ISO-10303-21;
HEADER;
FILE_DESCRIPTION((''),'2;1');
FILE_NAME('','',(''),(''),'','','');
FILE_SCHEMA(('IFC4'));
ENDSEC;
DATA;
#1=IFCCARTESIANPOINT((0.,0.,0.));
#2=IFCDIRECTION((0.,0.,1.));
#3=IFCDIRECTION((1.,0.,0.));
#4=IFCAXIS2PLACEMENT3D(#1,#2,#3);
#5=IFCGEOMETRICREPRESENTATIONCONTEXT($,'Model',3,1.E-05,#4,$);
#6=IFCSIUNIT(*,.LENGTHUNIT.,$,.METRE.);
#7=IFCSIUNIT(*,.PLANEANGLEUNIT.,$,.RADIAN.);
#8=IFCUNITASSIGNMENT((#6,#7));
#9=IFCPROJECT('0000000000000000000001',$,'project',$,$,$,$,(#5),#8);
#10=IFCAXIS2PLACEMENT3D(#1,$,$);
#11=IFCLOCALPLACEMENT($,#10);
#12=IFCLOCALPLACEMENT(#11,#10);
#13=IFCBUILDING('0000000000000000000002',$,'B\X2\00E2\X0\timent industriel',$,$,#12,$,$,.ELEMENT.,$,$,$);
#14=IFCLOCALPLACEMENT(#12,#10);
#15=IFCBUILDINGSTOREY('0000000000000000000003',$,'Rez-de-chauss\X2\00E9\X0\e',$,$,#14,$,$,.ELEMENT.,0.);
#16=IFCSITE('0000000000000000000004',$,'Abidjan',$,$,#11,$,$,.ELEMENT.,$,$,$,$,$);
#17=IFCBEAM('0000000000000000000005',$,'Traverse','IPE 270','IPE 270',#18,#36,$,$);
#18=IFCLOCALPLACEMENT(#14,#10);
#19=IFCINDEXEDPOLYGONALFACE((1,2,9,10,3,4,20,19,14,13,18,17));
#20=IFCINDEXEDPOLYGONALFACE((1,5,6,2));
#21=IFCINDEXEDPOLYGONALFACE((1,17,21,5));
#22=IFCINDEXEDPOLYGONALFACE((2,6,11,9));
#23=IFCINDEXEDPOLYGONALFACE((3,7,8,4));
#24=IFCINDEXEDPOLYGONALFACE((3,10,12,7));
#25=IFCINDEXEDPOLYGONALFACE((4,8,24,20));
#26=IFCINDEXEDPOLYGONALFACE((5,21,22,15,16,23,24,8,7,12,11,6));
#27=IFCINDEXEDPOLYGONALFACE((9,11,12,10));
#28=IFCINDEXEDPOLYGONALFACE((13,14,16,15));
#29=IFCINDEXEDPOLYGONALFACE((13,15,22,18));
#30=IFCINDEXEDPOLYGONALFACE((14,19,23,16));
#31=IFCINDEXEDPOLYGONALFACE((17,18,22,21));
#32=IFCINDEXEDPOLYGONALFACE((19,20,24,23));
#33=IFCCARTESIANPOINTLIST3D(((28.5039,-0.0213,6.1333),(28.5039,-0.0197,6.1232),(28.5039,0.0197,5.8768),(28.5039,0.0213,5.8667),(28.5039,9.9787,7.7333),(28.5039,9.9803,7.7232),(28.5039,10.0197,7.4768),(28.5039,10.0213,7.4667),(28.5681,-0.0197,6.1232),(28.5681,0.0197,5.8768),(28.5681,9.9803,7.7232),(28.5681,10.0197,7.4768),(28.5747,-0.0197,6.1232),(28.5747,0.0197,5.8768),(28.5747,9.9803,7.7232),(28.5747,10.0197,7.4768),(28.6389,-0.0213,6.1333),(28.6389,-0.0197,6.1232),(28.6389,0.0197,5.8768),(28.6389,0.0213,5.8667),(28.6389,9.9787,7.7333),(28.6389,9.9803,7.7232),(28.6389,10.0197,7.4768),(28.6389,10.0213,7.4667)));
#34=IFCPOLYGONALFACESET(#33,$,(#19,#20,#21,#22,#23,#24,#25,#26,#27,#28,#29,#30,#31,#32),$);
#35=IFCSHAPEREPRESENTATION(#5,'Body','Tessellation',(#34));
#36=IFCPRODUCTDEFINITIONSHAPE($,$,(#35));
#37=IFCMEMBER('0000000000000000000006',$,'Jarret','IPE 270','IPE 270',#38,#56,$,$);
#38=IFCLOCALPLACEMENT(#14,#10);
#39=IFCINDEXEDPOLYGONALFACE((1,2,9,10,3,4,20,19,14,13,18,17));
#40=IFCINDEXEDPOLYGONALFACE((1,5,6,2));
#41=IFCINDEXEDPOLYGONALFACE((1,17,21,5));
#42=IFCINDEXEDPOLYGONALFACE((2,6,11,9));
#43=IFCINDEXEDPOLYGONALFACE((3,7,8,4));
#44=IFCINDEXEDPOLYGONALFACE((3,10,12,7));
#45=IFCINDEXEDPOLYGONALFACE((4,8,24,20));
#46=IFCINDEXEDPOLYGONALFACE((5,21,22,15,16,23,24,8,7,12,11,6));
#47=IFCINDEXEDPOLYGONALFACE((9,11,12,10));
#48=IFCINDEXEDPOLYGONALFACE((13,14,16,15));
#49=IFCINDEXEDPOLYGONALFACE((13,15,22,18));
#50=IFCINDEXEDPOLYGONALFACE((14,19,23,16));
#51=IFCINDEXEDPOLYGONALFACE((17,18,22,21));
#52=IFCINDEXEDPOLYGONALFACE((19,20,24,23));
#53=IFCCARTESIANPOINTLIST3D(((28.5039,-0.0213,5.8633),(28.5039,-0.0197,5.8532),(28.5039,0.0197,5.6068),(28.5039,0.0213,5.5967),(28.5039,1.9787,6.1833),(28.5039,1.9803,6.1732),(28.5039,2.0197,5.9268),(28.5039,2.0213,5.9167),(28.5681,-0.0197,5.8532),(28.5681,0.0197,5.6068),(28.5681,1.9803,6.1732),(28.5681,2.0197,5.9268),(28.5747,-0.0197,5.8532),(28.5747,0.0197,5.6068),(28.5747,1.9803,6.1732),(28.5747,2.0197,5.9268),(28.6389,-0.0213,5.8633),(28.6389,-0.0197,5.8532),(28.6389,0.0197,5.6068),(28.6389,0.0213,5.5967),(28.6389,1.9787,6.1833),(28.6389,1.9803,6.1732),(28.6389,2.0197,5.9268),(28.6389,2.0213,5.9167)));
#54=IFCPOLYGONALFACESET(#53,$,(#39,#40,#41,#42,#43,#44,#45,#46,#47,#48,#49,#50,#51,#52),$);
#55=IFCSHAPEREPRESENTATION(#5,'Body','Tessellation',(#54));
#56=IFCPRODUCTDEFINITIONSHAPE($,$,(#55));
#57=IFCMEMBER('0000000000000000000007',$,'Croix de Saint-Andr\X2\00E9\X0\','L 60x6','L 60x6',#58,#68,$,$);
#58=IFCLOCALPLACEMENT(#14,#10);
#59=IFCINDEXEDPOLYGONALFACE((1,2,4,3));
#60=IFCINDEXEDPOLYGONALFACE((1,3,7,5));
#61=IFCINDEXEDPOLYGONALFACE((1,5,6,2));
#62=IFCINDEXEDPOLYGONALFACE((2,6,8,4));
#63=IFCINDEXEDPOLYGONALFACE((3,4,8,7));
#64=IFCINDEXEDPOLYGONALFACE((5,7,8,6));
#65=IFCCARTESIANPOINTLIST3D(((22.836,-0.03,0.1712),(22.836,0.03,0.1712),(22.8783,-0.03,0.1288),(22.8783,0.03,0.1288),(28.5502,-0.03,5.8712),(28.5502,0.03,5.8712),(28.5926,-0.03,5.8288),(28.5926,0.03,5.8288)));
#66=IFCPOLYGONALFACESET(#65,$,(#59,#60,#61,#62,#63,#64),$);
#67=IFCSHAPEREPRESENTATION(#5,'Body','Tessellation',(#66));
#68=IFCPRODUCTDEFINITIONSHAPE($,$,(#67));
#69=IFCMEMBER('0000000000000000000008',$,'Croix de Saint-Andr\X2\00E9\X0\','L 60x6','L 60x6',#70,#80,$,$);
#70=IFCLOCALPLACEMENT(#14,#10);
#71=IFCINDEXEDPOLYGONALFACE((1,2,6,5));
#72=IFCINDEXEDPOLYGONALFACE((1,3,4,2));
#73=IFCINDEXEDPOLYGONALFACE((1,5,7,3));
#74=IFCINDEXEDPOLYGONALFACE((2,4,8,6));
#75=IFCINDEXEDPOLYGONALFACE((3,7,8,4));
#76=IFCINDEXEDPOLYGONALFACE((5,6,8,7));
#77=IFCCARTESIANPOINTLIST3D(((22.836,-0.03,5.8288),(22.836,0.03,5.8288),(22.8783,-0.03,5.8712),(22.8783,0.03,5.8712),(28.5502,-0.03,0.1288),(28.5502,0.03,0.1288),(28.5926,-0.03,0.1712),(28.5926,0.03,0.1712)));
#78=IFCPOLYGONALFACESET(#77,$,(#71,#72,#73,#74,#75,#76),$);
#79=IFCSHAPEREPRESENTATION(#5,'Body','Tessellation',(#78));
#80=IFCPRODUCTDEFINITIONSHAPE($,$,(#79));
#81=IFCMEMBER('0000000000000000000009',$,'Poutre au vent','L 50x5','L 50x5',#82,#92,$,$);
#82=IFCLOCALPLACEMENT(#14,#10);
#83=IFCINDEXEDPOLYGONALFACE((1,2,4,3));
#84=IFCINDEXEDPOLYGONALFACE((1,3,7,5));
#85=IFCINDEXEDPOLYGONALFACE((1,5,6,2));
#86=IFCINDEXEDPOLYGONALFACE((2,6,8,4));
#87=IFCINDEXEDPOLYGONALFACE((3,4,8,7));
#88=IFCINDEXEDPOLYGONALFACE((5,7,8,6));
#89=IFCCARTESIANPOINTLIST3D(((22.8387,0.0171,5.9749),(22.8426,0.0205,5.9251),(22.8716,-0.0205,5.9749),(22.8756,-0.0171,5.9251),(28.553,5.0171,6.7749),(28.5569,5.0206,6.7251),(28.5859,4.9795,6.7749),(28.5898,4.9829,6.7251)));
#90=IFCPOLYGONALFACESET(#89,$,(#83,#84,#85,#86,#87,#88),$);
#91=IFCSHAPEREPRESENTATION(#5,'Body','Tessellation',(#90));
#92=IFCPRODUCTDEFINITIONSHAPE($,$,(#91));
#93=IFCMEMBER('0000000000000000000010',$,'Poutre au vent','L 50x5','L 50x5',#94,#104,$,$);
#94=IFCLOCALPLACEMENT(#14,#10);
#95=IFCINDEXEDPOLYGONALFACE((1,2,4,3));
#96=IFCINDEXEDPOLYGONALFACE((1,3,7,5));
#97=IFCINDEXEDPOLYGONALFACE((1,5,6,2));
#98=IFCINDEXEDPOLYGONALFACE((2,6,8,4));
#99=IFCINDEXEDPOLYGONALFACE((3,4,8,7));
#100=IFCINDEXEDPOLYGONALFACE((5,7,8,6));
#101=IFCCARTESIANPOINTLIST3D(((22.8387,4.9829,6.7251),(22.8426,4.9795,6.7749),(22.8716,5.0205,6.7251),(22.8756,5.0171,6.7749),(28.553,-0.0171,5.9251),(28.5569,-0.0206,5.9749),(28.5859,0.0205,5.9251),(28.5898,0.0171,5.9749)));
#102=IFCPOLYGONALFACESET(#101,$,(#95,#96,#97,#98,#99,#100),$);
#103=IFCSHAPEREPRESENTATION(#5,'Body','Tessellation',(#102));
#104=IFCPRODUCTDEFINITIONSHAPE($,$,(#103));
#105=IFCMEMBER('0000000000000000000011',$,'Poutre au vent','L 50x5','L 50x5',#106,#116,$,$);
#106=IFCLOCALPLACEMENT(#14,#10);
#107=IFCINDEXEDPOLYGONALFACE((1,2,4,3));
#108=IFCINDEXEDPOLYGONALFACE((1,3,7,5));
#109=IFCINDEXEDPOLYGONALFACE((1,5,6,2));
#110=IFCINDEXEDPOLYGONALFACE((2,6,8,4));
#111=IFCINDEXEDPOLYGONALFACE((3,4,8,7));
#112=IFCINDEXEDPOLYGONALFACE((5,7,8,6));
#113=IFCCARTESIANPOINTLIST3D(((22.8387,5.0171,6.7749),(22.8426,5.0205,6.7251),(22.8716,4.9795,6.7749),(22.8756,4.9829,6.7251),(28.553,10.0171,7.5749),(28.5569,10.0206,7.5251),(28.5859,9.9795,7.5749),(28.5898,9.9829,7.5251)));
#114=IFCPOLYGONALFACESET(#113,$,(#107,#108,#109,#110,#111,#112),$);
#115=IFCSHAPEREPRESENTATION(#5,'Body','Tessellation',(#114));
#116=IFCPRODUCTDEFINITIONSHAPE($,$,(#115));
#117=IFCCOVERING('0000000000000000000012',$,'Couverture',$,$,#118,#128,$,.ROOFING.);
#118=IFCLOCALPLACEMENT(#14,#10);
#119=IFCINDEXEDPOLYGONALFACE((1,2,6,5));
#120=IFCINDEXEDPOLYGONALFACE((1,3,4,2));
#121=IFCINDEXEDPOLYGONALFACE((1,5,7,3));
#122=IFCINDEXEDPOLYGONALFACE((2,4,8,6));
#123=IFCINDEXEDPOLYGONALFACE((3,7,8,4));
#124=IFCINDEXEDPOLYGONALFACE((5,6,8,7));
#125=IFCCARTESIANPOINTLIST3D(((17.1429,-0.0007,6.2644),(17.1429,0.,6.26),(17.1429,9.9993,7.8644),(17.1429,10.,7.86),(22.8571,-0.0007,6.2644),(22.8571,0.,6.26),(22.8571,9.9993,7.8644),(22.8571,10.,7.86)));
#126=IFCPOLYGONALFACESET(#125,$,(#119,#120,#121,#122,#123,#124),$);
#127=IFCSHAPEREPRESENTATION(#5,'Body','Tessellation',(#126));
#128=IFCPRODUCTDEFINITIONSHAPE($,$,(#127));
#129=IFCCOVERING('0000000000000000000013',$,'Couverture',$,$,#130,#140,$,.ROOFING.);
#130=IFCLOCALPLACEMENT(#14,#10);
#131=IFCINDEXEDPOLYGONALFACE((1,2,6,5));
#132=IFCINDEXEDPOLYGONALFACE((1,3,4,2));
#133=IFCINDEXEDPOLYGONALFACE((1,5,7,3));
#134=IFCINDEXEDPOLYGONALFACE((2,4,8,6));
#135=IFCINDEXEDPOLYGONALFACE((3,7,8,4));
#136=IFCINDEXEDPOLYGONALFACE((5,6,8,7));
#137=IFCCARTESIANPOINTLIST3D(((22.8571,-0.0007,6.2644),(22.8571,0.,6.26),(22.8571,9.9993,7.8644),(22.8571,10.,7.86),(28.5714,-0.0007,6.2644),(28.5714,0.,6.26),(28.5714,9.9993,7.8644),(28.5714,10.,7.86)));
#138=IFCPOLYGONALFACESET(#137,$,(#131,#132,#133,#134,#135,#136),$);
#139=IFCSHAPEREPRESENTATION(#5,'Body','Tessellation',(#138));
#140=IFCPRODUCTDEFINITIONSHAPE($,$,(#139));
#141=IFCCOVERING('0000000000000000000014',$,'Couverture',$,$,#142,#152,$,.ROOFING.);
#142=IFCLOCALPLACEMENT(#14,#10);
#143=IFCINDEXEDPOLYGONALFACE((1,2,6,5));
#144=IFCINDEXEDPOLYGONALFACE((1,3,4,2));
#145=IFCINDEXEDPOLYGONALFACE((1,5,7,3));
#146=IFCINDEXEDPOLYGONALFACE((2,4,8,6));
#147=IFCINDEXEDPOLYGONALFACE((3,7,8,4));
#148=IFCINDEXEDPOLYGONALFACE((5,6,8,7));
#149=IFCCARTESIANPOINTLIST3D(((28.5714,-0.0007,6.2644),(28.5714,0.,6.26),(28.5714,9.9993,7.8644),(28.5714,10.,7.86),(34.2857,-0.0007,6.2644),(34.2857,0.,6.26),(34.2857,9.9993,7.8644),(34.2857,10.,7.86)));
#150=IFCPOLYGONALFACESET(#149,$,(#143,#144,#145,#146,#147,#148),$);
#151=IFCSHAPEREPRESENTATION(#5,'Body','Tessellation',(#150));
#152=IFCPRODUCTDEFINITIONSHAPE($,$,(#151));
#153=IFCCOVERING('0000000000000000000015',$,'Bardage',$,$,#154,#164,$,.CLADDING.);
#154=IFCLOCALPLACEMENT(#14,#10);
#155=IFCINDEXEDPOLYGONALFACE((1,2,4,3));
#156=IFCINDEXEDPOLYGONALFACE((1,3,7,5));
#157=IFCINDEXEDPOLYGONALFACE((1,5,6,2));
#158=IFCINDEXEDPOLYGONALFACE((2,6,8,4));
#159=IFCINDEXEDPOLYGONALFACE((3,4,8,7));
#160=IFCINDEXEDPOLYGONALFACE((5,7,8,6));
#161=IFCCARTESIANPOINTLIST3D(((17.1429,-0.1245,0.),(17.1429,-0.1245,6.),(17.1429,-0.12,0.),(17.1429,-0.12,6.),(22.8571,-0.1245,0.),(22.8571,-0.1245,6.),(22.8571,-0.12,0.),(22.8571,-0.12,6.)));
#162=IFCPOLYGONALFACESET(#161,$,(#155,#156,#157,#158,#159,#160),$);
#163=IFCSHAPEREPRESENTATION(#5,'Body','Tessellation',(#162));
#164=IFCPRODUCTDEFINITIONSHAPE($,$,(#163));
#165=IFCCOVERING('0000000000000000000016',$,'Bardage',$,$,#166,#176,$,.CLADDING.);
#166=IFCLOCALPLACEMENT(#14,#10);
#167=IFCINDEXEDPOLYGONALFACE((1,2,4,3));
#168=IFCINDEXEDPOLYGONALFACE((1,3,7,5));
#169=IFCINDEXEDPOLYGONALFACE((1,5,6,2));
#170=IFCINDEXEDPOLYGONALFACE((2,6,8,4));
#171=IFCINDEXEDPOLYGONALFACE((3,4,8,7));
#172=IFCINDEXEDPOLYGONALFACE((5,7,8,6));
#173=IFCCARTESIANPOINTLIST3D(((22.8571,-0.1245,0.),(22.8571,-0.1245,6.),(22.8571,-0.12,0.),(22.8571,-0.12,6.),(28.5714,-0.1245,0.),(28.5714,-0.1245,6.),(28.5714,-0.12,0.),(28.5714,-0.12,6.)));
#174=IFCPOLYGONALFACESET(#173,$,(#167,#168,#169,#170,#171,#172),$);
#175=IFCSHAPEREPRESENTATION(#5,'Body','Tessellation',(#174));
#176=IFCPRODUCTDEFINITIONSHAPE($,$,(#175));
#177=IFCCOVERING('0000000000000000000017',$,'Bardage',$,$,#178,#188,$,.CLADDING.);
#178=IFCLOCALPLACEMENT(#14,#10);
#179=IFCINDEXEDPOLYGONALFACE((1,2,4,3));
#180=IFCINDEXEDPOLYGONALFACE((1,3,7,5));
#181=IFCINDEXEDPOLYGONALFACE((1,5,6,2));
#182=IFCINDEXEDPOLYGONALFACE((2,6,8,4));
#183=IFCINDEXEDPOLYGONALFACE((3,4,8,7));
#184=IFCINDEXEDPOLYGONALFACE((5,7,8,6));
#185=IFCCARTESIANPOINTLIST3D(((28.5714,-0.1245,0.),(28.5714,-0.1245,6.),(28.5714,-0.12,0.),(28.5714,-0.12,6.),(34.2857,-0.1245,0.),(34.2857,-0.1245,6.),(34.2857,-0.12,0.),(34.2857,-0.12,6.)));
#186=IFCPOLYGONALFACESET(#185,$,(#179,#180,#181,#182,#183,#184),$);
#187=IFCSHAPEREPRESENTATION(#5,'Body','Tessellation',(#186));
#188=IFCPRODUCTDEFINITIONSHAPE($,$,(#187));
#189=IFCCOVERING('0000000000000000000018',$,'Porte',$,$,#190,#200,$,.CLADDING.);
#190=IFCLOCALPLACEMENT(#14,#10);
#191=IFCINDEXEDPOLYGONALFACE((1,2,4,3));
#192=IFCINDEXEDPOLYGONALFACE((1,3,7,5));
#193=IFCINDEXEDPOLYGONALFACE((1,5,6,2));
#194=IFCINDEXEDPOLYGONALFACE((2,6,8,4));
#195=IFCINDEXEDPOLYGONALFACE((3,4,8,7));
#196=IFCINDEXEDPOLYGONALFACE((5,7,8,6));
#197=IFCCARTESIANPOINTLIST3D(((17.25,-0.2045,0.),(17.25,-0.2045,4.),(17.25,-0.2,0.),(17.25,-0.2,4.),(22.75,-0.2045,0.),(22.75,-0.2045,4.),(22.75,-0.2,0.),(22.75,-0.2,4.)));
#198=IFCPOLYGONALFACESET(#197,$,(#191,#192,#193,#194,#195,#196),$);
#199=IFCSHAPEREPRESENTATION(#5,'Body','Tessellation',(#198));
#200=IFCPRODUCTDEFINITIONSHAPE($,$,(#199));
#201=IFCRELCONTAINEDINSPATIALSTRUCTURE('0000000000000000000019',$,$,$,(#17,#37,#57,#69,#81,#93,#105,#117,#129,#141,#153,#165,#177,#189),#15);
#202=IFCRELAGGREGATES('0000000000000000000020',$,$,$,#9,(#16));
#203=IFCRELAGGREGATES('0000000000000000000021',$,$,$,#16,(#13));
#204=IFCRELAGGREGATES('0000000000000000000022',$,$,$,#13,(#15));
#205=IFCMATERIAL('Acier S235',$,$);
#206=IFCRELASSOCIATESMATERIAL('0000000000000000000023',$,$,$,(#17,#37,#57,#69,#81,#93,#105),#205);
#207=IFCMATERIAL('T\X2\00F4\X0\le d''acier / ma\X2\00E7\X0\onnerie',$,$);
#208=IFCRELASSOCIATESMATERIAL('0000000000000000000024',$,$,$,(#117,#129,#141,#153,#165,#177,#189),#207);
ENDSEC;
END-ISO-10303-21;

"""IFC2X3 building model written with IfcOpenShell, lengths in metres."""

from ifc_helpers import new_model, si_unit, frame, origin, origin_with_axes, origin_2d, place, context, project, spatial, polyline, rectangle, i_section, outline, extrude, material, element, save


model = new_model("IFC2X3")

# Units and contexts
model_context = context("Model", 3, precision=1e-05, world=origin_with_axes())
ifc_project = project(units=[si_unit("LENGTHUNIT", "METRE"), si_unit("PLANEANGLEUNIT", "RADIAN")], contexts=[model_context])

# Site, building, storey
site_placement = place(None, origin())
site = spatial("IfcSite", under=ifc_project, at=site_placement, Name="Abidjan", CompositionType="ELEMENT")
building_placement = place(site_placement, origin())
building = spatial("IfcBuilding", under=site, at=building_placement, Name="Bâtiment industriel", CompositionType="ELEMENT")
storey_placement = place(building_placement, origin())
storey = spatial("IfcBuildingStorey", under=building, at=storey_placement, Name="Rez-de-chaussée", CompositionType="ELEMENT", Elevation=0.0)

# Shared definitions
ifc_material_1 = material(Name="Acier S235")

# Beam
beam_1_placement = place(storey_placement, frame((28.5714, 0.0, 6.0), z_axis=(0.0, 0.98744, 0.15799), x_axis=(1.0, 0.0, 0.0)))
element("IfcBeam", 1, at=beam_1_placement, inside=storey, material=ifc_material_1, Name="Traverse", Description="IPE 270", ObjectType="IPE 270", context=model_context, shape_type="SweptSolid", body=[
    extrude(i_section(OverallWidth=0.135, OverallDepth=0.27, WebThickness=0.0066, FlangeThickness=0.0102, at=origin_2d()), origin(), (0.0, 0.0, 1.0), 10.1272),
])

# Members
member_1_placement = place(storey_placement, frame((28.5714, 0.0, 5.73), z_axis=(0.0, 0.98744, 0.15799), x_axis=(1.0, 0.0, 0.0)))
element("IfcMember", 2, at=member_1_placement, inside=storey, material=ifc_material_1, Name="Jarret", Description="IPE 270", ObjectType="IPE 270", context=model_context, shape_type="SweptSolid", body=[
    extrude(i_section(OverallWidth=0.135, OverallDepth=0.27, WebThickness=0.0066, FlangeThickness=0.0102, at=origin_2d()), origin(), (0.0, 0.0, 1.0), 2.0254),
])
for number, where, z_axis, x_axis, name in (
    (3, (22.8571, 0.0, 0.15), (0.70799, 0.0, 0.70622), (0.0, 1.0, 0.0), "Croix de Saint-André"),
    (4, (28.5714, 0.0, 0.15), (-0.70799, 0.0, 0.70622), (0.0, 1.0, 0.0), "Croix de Saint-André"),
):
    element("IfcMember", number, at=place(storey_placement, frame(where, z_axis=z_axis, x_axis=x_axis)), inside=storey, material=ifc_material_1, Name=name, Description="L 60x6", ObjectType="L 60x6", context=model_context, shape_type="SweptSolid", body=[
        extrude(rectangle(XDim=0.06, YDim=0.06, at=origin_2d()), origin(), (0.0, 0.0, 1.0), 8.0711),
    ])
for number, where, z_axis, x_axis, name in (
    (5, (22.8571, 0.0, 5.95), (0.74843, 0.65488, 0.10478), (-0.07886, -0.069, 0.9945), "Poutre au vent"),
    (6, (22.8571, 5.0, 6.75), (0.74843, -0.65488, -0.10478), (0.07886, -0.069, 0.9945), "Poutre au vent"),
    (7, (22.8571, 5.0, 6.75), (0.74843, 0.65488, 0.10478), (-0.07886, -0.069, 0.9945), "Poutre au vent"),
):
    element("IfcMember", number, at=place(storey_placement, frame(where, z_axis=z_axis, x_axis=x_axis)), inside=storey, material=ifc_material_1, Name=name, Description="L 50x5", ObjectType="L 50x5", context=model_context, shape_type="SweptSolid", body=[
        extrude(rectangle(XDim=0.05, YDim=0.05, at=origin_2d()), origin(), (0.0, 0.0, 1.0), 7.635),
    ])

# Coverings
ifc_material_2 = material(Name="Tôle d'acier / maçonnerie")
for number, where, z_axis, x_axis, name in (
    (8, (17.1429, 0.0, 6.26), (0.0, -0.15799, 0.98744), (1.0, 0.0, 0.0), "Couverture"),
    (9, (22.8571, 0.0, 6.26), (0.0, -0.15799, 0.98744), (1.0, 0.0, 0.0), "Couverture"),
    (10, (28.5714, 0.0, 6.26), (0.0, -0.15799, 0.98744), (1.0, 0.0, 0.0), "Couverture"),
):
    element("IfcCovering", number, at=place(storey_placement, frame(where, z_axis=z_axis, x_axis=x_axis)), inside=storey, material=ifc_material_2, Name=name, PredefinedType="ROOFING", context=model_context, shape_type="SweptSolid", body=[
        extrude(outline(polyline([(0.0, 0.0), (5.7143, 0.0), (5.7143, 10.1272), (0.0, 10.1272), (0.0, 0.0)])), origin(), (0.0, 0.0, 1.0), 0.0045),
    ])
for number, where, z_axis, x_axis, name in (
    (11, (17.1429, -0.12, 0.0), (0.0, -1.0, 0.0), (1.0, 0.0, 0.0), "Bardage"),
    (12, (22.8571, -0.12, 0.0), (0.0, -1.0, 0.0), (1.0, 0.0, 0.0), "Bardage"),
    (13, (28.5714, -0.12, 0.0), (0.0, -1.0, 0.0), (1.0, 0.0, 0.0), "Bardage"),
):
    element("IfcCovering", number, at=place(storey_placement, frame(where, z_axis=z_axis, x_axis=x_axis)), inside=storey, material=ifc_material_2, Name=name, PredefinedType="CLADDING", context=model_context, shape_type="SweptSolid", body=[
        extrude(outline(polyline([(0.0, 0.0), (5.7143, 0.0), (5.7143, 6.0), (0.0, 6.0), (0.0, 0.0)])), origin(), (0.0, 0.0, 1.0), 0.0045),
    ])
covering_placement = place(storey_placement, frame((17.25, -0.2, 0.0), z_axis=(0.0, -1.0, 0.0), x_axis=(1.0, 0.0, 0.0)))
element("IfcCovering", 14, at=covering_placement, inside=storey, material=ifc_material_2, Name="Porte", PredefinedType="CLADDING", context=model_context, shape_type="SweptSolid", body=[
    extrude(outline(polyline([(0.0, 0.0), (5.5, 0.0), (5.5, 4.0), (0.0, 4.0), (0.0, 0.0)])), origin(), (0.0, 0.0, 1.0), 0.0045),
])

save(model, "model.ifc")
